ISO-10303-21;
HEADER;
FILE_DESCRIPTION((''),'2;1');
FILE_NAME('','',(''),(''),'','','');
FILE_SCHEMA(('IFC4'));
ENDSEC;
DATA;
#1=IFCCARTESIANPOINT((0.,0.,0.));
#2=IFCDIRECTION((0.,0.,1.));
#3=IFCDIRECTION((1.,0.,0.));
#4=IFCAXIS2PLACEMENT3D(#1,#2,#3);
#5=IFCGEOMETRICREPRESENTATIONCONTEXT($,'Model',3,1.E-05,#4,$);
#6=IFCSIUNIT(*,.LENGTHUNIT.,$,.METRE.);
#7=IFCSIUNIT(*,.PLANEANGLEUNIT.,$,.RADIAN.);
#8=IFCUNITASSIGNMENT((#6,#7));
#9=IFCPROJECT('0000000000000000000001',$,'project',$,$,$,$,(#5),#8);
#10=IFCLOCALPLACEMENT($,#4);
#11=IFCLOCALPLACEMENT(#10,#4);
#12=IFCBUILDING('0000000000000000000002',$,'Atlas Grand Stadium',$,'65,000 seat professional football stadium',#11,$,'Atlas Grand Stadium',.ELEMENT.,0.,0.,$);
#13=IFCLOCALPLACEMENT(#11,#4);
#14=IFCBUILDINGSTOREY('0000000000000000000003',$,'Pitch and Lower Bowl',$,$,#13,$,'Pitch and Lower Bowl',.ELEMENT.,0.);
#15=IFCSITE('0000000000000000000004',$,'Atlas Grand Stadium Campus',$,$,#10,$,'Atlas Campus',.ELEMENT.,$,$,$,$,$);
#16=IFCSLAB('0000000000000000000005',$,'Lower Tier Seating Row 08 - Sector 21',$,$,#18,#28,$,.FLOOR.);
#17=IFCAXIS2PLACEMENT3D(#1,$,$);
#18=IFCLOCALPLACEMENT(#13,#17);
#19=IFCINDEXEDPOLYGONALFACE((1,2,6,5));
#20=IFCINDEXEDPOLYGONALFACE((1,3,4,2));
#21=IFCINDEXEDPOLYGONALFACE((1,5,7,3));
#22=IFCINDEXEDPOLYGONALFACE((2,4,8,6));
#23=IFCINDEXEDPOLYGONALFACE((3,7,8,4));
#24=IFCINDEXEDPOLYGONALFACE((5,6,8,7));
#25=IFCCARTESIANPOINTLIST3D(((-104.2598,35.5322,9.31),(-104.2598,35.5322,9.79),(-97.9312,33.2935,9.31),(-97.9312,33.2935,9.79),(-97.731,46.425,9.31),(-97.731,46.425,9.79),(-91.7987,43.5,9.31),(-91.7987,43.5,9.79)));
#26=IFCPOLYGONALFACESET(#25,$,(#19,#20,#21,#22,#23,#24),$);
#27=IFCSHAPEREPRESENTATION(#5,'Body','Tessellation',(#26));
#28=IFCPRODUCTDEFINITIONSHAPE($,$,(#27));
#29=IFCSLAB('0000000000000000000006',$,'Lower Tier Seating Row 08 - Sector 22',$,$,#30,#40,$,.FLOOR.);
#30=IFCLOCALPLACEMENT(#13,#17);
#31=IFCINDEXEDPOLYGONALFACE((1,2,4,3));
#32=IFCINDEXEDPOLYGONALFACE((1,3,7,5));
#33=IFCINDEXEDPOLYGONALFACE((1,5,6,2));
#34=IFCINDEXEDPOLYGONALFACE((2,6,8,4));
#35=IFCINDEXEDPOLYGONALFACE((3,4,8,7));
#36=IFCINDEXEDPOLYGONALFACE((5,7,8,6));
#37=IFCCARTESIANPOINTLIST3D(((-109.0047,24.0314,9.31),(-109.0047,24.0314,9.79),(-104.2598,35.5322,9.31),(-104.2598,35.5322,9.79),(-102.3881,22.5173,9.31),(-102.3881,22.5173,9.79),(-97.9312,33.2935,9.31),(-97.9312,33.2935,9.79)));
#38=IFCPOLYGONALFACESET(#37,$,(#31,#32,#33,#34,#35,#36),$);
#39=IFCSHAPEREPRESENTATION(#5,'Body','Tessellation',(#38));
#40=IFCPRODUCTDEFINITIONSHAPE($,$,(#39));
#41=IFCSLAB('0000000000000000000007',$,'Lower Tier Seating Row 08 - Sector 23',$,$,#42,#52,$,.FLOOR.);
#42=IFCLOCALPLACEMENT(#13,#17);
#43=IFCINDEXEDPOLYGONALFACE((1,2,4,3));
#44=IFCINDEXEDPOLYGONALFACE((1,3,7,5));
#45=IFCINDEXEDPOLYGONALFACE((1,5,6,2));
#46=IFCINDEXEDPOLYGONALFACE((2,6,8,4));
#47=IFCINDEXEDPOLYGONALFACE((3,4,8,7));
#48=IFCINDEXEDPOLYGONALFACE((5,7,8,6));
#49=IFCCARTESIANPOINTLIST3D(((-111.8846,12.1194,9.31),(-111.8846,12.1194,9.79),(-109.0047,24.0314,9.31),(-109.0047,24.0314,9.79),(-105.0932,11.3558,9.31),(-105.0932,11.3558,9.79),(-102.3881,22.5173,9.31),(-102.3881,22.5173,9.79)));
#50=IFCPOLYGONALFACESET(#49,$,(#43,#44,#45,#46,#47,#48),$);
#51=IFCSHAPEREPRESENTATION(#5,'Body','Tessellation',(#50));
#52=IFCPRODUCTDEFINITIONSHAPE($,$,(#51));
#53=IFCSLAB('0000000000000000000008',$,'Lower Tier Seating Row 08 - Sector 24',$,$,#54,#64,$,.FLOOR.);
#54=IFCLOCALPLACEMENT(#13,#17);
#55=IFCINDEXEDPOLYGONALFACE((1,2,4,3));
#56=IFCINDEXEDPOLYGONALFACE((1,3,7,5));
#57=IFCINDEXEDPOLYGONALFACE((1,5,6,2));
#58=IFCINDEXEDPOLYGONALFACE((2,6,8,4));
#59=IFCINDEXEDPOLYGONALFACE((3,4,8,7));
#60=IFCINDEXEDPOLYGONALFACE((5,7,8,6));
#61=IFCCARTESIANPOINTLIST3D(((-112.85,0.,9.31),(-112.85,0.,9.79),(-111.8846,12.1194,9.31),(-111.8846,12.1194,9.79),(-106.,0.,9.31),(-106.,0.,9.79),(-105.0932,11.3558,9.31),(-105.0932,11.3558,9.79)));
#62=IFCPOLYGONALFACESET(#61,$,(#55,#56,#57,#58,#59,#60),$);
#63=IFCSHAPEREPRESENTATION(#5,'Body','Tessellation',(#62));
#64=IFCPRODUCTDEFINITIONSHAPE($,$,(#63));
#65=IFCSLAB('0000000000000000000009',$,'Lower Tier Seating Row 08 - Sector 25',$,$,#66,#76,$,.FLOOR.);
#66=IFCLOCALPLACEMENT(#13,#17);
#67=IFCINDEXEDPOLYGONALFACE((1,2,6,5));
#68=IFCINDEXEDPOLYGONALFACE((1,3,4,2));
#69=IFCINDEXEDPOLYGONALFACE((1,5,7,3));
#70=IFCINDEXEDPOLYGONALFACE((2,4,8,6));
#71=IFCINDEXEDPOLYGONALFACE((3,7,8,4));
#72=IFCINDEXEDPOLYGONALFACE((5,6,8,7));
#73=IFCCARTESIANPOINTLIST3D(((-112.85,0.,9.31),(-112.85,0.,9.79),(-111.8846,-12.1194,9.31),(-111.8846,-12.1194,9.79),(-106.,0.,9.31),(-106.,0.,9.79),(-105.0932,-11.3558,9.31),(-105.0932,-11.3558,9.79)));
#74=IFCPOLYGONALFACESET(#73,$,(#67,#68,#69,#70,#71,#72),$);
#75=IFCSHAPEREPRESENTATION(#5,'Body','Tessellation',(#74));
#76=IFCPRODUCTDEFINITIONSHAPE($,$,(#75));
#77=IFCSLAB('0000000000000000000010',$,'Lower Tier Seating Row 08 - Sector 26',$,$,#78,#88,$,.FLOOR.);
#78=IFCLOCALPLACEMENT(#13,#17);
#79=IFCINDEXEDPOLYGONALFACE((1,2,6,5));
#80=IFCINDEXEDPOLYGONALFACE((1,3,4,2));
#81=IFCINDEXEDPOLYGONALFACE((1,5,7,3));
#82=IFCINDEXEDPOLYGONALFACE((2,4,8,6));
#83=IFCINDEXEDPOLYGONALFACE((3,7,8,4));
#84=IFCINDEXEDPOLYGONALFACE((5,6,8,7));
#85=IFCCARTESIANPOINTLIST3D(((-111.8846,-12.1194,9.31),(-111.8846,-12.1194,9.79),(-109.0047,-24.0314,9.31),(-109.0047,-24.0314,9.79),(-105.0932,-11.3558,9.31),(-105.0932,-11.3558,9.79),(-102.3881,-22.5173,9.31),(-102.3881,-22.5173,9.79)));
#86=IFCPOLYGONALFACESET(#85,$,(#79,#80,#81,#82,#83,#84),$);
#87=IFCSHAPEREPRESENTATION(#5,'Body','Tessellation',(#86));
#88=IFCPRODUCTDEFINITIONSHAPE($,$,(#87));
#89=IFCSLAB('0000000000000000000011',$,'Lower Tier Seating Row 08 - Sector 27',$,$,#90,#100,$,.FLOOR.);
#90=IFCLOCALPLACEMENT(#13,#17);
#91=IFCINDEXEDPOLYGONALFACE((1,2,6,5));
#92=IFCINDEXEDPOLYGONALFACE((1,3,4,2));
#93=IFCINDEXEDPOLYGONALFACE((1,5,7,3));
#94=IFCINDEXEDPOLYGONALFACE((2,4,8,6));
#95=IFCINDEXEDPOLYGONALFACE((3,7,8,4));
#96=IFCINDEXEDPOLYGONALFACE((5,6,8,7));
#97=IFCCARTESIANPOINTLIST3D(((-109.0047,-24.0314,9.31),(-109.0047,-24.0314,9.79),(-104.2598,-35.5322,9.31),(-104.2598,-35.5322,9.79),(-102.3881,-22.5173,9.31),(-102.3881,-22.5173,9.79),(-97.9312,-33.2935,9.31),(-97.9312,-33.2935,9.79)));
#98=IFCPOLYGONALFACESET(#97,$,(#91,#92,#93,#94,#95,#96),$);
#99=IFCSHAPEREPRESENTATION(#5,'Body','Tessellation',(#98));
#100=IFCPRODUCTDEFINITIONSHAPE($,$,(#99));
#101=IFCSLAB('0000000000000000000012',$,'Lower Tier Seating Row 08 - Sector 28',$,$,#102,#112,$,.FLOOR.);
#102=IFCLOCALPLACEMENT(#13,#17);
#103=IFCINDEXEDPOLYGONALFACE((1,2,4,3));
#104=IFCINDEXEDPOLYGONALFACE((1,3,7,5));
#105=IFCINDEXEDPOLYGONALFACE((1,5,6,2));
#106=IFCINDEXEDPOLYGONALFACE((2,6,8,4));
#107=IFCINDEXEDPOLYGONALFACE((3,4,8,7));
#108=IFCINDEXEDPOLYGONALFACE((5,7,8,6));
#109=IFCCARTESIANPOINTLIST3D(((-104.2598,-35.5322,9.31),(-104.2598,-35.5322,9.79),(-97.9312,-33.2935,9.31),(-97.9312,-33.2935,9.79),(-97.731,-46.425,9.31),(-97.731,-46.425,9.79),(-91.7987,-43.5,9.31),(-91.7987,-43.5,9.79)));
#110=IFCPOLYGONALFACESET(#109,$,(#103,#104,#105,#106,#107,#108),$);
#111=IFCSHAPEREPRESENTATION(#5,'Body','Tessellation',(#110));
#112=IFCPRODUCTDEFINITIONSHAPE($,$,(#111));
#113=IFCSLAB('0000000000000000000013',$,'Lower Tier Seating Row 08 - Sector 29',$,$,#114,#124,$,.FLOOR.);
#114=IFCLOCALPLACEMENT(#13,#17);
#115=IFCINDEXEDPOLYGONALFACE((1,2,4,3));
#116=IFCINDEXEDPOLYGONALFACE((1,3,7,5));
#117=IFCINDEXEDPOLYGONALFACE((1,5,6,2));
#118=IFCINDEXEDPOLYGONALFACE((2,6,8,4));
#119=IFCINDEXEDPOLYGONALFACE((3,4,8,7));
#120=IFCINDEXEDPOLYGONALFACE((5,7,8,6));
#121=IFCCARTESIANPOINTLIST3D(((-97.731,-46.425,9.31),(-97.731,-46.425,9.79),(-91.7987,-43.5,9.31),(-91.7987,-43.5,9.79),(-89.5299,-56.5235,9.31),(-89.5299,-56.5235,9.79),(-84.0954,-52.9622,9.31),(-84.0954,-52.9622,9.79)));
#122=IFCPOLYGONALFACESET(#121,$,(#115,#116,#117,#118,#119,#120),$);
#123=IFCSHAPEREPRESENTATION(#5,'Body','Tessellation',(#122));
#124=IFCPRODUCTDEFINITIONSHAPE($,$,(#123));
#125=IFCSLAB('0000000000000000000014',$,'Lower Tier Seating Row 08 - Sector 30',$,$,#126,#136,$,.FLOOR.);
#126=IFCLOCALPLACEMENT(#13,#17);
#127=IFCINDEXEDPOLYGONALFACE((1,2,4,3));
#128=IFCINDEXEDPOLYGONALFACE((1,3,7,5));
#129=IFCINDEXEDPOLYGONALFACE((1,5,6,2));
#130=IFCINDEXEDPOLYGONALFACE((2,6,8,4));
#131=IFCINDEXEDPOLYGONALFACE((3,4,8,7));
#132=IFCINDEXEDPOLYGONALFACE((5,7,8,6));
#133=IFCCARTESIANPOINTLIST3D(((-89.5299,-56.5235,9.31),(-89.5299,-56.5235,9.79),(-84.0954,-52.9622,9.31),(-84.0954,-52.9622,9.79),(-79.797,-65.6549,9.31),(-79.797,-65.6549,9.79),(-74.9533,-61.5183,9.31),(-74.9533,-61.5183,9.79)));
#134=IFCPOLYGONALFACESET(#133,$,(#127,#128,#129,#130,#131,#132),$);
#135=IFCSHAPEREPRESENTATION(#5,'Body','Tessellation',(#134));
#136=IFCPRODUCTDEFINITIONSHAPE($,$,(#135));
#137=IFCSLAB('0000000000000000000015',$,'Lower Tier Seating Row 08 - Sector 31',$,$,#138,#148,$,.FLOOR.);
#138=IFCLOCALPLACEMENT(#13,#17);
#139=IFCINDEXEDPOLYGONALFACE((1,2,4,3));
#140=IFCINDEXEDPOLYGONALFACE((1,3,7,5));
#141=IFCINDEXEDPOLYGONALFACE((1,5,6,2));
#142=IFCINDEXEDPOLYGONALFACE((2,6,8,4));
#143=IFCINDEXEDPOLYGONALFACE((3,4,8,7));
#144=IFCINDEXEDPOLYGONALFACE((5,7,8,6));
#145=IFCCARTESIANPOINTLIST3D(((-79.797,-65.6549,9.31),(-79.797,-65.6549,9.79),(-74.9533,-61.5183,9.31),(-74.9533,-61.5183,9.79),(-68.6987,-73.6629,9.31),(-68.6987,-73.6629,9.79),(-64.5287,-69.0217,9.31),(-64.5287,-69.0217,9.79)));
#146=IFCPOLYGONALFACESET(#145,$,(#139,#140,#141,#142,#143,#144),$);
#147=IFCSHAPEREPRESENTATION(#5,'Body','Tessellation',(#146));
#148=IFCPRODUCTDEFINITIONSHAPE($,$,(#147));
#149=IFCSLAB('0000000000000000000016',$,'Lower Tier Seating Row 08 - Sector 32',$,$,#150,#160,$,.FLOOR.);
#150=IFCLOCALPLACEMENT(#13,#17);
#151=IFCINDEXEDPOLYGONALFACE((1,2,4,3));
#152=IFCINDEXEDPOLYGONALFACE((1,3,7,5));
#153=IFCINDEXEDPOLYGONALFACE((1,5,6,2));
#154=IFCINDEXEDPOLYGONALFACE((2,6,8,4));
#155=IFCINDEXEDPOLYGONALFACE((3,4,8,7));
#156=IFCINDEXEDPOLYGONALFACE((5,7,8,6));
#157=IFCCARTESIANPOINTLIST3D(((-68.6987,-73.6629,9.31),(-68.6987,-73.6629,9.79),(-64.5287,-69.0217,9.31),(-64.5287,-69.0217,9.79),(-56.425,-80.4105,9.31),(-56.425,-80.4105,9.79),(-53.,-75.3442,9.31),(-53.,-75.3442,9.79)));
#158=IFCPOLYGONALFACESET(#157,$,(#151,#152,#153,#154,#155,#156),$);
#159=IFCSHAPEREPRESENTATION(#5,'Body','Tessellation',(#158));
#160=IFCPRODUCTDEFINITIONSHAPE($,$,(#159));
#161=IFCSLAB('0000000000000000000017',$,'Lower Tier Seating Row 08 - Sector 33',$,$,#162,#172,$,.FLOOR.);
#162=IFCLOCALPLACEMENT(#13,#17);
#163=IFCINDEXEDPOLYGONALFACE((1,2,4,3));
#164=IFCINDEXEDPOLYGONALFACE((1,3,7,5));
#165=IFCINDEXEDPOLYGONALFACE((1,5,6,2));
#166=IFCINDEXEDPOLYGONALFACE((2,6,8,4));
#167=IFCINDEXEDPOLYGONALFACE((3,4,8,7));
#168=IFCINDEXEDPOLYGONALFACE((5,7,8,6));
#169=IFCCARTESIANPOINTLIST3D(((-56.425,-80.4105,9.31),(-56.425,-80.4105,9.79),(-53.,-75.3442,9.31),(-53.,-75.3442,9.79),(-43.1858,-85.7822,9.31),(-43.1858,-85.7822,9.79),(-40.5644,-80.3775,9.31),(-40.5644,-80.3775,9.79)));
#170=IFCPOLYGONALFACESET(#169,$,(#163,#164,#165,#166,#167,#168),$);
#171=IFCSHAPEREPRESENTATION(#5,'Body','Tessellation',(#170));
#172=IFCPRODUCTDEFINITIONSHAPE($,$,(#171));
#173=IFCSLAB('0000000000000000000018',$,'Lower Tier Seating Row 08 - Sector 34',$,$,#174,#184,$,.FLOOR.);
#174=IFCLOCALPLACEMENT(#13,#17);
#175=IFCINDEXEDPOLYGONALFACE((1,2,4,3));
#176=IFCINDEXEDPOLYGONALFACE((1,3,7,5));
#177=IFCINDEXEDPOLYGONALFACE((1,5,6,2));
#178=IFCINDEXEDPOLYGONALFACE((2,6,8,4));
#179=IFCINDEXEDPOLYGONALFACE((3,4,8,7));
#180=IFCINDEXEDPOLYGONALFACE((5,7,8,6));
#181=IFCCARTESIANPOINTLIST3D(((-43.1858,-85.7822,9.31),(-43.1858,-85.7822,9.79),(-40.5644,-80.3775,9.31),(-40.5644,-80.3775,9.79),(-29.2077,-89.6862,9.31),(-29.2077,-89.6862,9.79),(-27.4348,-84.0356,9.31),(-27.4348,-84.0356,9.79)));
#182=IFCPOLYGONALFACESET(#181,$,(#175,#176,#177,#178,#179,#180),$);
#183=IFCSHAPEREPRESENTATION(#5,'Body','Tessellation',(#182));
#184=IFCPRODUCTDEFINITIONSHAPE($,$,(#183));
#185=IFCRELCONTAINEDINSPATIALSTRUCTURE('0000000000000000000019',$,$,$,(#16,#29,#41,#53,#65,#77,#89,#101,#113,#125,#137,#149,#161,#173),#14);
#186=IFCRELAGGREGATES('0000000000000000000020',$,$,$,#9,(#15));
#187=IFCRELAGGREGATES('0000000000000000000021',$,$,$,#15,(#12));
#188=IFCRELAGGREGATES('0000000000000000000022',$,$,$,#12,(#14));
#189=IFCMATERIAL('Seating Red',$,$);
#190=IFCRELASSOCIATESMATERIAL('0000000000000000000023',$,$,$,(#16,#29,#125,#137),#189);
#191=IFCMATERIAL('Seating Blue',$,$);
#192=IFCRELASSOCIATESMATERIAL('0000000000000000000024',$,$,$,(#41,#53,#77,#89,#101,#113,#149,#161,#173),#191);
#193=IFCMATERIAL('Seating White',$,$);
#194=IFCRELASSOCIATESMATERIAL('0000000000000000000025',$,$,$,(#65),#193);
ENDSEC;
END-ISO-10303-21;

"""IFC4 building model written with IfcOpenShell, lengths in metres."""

from ifc_helpers import new_model, si_unit, frame, origin_with_axes, place, context, project, spatial, polyline, outline, extrude, material, element, save


model = new_model("IFC4")

# Units and contexts
model_context = context("Model", 3, precision=1e-05, world=origin_with_axes())
ifc_project = project(units=[si_unit("LENGTHUNIT", "METRE"), si_unit("PLANEANGLEUNIT", "RADIAN")], contexts=[model_context])

# Site, building, storey
site_placement = place(None, origin_with_axes())
site = spatial("IfcSite", under=ifc_project, at=site_placement, Name="Atlas Grand Stadium Campus", LongName="Atlas Campus", CompositionType="ELEMENT")
building_placement = place(site_placement, origin_with_axes())
building = spatial("IfcBuilding", under=site, at=building_placement, Name="Atlas Grand Stadium", ObjectType="65,000 seat professional football stadium", LongName="Atlas Grand Stadium", CompositionType="ELEMENT", ElevationOfRefHeight=0.0, ElevationOfTerrain=0.0)
storey_placement = place(building_placement, origin_with_axes())
storey = spatial("IfcBuildingStorey", under=building, at=storey_placement, Name="Pitch and Lower Bowl", LongName="Pitch and Lower Bowl", CompositionType="ELEMENT", Elevation=0.0)

# Slabs
ifc_material_1 = material(Name="Seating Red")
slab_1_placement = place(storey_placement, frame((0.0, 0.0, 9.31), z_axis=(0.0, 0.0, 1.0), x_axis=(1.0, 0.0, 0.0)))
element("IfcSlab", 1, at=slab_1_placement, inside=storey, material=ifc_material_1, Name="Lower Tier Seating Row 08 - Sector 21", PredefinedType="FLOOR", context=model_context, shape_type="SweptSolid", body=[
    extrude(outline(polyline([(-97.731, 46.425), (-104.2598, 35.5322), (-97.9312, 33.2935), (-91.7987, 43.5), (-97.731, 46.425)])), origin_with_axes(), (0.0, 0.0, 1.0), 0.48),
])
slab_2_placement = place(storey_placement, frame((0.0, 0.0, 9.31), z_axis=(0.0, 0.0, 1.0), x_axis=(1.0, 0.0, 0.0)))
element("IfcSlab", 2, at=slab_2_placement, inside=storey, material=ifc_material_1, Name="Lower Tier Seating Row 08 - Sector 22", PredefinedType="FLOOR", context=model_context, shape_type="SweptSolid", body=[
    extrude(outline(polyline([(-104.2598, 35.5322), (-109.0047, 24.0313), (-102.3881, 22.5173), (-97.9312, 33.2935), (-104.2598, 35.5322)])), origin_with_axes(), (0.0, 0.0, 1.0), 0.48),
])
ifc_material_2 = material(Name="Seating Blue")
slab_3_placement = place(storey_placement, frame((0.0, 0.0, 9.31), z_axis=(0.0, 0.0, 1.0), x_axis=(1.0, 0.0, 0.0)))
element("IfcSlab", 3, at=slab_3_placement, inside=storey, material=ifc_material_2, Name="Lower Tier Seating Row 08 - Sector 23", PredefinedType="FLOOR", context=model_context, shape_type="SweptSolid", body=[
    extrude(outline(polyline([(-109.0047, 24.0313), (-111.8846, 12.1194), (-105.0932, 11.3558), (-102.3881, 22.5173), (-109.0047, 24.0313)])), origin_with_axes(), (0.0, 0.0, 1.0), 0.48),
])
slab_4_placement = place(storey_placement, frame((0.0, 0.0, 9.31), z_axis=(0.0, 0.0, 1.0), x_axis=(1.0, 0.0, 0.0)))
element("IfcSlab", 4, at=slab_4_placement, inside=storey, material=ifc_material_2, Name="Lower Tier Seating Row 08 - Sector 24", PredefinedType="FLOOR", context=model_context, shape_type="SweptSolid", body=[
    extrude(outline(polyline([(-111.8846, 12.1194), (-112.85, 0.0), (-106.0, 0.0), (-105.0932, 11.3558), (-111.8846, 12.1194)])), origin_with_axes(), (0.0, 0.0, 1.0), 0.48),
])
ifc_material_3 = material(Name="Seating White")
slab_5_placement = place(storey_placement, frame((0.0, 0.0, 9.31), z_axis=(0.0, 0.0, 1.0), x_axis=(1.0, 0.0, 0.0)))
element("IfcSlab", 5, at=slab_5_placement, inside=storey, material=ifc_material_3, Name="Lower Tier Seating Row 08 - Sector 25", PredefinedType="FLOOR", context=model_context, shape_type="SweptSolid", body=[
    extrude(outline(polyline([(-112.85, 0.0), (-111.8846, -12.1194), (-105.0932, -11.3558), (-106.0, 0.0), (-112.85, 0.0)])), origin_with_axes(), (0.0, 0.0, 1.0), 0.48),
])
slab_6_placement = place(storey_placement, frame((0.0, 0.0, 9.31), z_axis=(0.0, 0.0, 1.0), x_axis=(1.0, 0.0, 0.0)))
element("IfcSlab", 6, at=slab_6_placement, inside=storey, material=ifc_material_2, Name="Lower Tier Seating Row 08 - Sector 26", PredefinedType="FLOOR", context=model_context, shape_type="SweptSolid", body=[
    extrude(outline(polyline([(-111.8846, -12.1194), (-109.0047, -24.0313), (-102.3881, -22.5173), (-105.0932, -11.3558), (-111.8846, -12.1194)])), origin_with_axes(), (0.0, 0.0, 1.0), 0.48),
])
slab_7_placement = place(storey_placement, frame((0.0, 0.0, 9.31), z_axis=(0.0, 0.0, 1.0), x_axis=(1.0, 0.0, 0.0)))
element("IfcSlab", 7, at=slab_7_placement, inside=storey, material=ifc_material_2, Name="Lower Tier Seating Row 08 - Sector 27", PredefinedType="FLOOR", context=model_context, shape_type="SweptSolid", body=[
    extrude(outline(polyline([(-109.0047, -24.0313), (-104.2598, -35.5322), (-97.9312, -33.2935), (-102.3881, -22.5173), (-109.0047, -24.0313)])), origin_with_axes(), (0.0, 0.0, 1.0), 0.48),
])
slab_8_placement = place(storey_placement, frame((0.0, 0.0, 9.31), z_axis=(0.0, 0.0, 1.0), x_axis=(1.0, 0.0, 0.0)))
element("IfcSlab", 8, at=slab_8_placement, inside=storey, material=ifc_material_2, Name="Lower Tier Seating Row 08 - Sector 28", PredefinedType="FLOOR", context=model_context, shape_type="SweptSolid", body=[
    extrude(outline(polyline([(-104.2598, -35.5322), (-97.731, -46.425), (-91.7987, -43.5), (-97.9312, -33.2935), (-104.2598, -35.5322)])), origin_with_axes(), (0.0, 0.0, 1.0), 0.48),
])
slab_9_placement = place(storey_placement, frame((0.0, 0.0, 9.31), z_axis=(0.0, 0.0, 1.0), x_axis=(1.0, 0.0, 0.0)))
element("IfcSlab", 9, at=slab_9_placement, inside=storey, material=ifc_material_2, Name="Lower Tier Seating Row 08 - Sector 29", PredefinedType="FLOOR", context=model_context, shape_type="SweptSolid", body=[
    extrude(outline(polyline([(-97.731, -46.425), (-89.5299, -56.5235), (-84.0954, -52.9622), (-91.7987, -43.5), (-97.731, -46.425)])), origin_with_axes(), (0.0, 0.0, 1.0), 0.48),
])
slab_10_placement = place(storey_placement, frame((0.0, 0.0, 9.31), z_axis=(0.0, 0.0, 1.0), x_axis=(1.0, 0.0, 0.0)))
element("IfcSlab", 10, at=slab_10_placement, inside=storey, material=ifc_material_1, Name="Lower Tier Seating Row 08 - Sector 30", PredefinedType="FLOOR", context=model_context, shape_type="SweptSolid", body=[
    extrude(outline(polyline([(-89.5299, -56.5235), (-79.797, -65.6549), (-74.9533, -61.5183), (-84.0954, -52.9622), (-89.5299, -56.5235)])), origin_with_axes(), (0.0, 0.0, 1.0), 0.48),
])
slab_11_placement = place(storey_placement, frame((0.0, 0.0, 9.31), z_axis=(0.0, 0.0, 1.0), x_axis=(1.0, 0.0, 0.0)))
element("IfcSlab", 11, at=slab_11_placement, inside=storey, material=ifc_material_1, Name="Lower Tier Seating Row 08 - Sector 31", PredefinedType="FLOOR", context=model_context, shape_type="SweptSolid", body=[
    extrude(outline(polyline([(-79.797, -65.6549), (-68.6987, -73.6629), (-64.5287, -69.0217), (-74.9533, -61.5183), (-79.797, -65.6549)])), origin_with_axes(), (0.0, 0.0, 1.0), 0.48),
])
slab_12_placement = place(storey_placement, frame((0.0, 0.0, 9.31), z_axis=(0.0, 0.0, 1.0), x_axis=(1.0, 0.0, 0.0)))
element("IfcSlab", 12, at=slab_12_placement, inside=storey, material=ifc_material_2, Name="Lower Tier Seating Row 08 - Sector 32", PredefinedType="FLOOR", context=model_context, shape_type="SweptSolid", body=[
    extrude(outline(polyline([(-68.6987, -73.6629), (-56.425, -80.4105), (-53.0, -75.3442), (-64.5287, -69.0217), (-68.6987, -73.6629)])), origin_with_axes(), (0.0, 0.0, 1.0), 0.48),
])
slab_13_placement = place(storey_placement, frame((0.0, 0.0, 9.31), z_axis=(0.0, 0.0, 1.0), x_axis=(1.0, 0.0, 0.0)))
element("IfcSlab", 13, at=slab_13_placement, inside=storey, material=ifc_material_2, Name="Lower Tier Seating Row 08 - Sector 33", PredefinedType="FLOOR", context=model_context, shape_type="SweptSolid", body=[
    extrude(outline(polyline([(-56.425, -80.4105), (-43.1858, -85.7822), (-40.5644, -80.3775), (-53.0, -75.3442), (-56.425, -80.4105)])), origin_with_axes(), (0.0, 0.0, 1.0), 0.48),
])
slab_14_placement = place(storey_placement, frame((0.0, 0.0, 9.31), z_axis=(0.0, 0.0, 1.0), x_axis=(1.0, 0.0, 0.0)))
element("IfcSlab", 14, at=slab_14_placement, inside=storey, material=ifc_material_2, Name="Lower Tier Seating Row 08 - Sector 34", PredefinedType="FLOOR", context=model_context, shape_type="SweptSolid", body=[
    extrude(outline(polyline([(-43.1858, -85.7822), (-29.2077, -89.6862), (-27.4348, -84.0356), (-40.5644, -80.3775), (-43.1858, -85.7822)])), origin_with_axes(), (0.0, 0.0, 1.0), 0.48),
])

save(model, "model.ifc")
